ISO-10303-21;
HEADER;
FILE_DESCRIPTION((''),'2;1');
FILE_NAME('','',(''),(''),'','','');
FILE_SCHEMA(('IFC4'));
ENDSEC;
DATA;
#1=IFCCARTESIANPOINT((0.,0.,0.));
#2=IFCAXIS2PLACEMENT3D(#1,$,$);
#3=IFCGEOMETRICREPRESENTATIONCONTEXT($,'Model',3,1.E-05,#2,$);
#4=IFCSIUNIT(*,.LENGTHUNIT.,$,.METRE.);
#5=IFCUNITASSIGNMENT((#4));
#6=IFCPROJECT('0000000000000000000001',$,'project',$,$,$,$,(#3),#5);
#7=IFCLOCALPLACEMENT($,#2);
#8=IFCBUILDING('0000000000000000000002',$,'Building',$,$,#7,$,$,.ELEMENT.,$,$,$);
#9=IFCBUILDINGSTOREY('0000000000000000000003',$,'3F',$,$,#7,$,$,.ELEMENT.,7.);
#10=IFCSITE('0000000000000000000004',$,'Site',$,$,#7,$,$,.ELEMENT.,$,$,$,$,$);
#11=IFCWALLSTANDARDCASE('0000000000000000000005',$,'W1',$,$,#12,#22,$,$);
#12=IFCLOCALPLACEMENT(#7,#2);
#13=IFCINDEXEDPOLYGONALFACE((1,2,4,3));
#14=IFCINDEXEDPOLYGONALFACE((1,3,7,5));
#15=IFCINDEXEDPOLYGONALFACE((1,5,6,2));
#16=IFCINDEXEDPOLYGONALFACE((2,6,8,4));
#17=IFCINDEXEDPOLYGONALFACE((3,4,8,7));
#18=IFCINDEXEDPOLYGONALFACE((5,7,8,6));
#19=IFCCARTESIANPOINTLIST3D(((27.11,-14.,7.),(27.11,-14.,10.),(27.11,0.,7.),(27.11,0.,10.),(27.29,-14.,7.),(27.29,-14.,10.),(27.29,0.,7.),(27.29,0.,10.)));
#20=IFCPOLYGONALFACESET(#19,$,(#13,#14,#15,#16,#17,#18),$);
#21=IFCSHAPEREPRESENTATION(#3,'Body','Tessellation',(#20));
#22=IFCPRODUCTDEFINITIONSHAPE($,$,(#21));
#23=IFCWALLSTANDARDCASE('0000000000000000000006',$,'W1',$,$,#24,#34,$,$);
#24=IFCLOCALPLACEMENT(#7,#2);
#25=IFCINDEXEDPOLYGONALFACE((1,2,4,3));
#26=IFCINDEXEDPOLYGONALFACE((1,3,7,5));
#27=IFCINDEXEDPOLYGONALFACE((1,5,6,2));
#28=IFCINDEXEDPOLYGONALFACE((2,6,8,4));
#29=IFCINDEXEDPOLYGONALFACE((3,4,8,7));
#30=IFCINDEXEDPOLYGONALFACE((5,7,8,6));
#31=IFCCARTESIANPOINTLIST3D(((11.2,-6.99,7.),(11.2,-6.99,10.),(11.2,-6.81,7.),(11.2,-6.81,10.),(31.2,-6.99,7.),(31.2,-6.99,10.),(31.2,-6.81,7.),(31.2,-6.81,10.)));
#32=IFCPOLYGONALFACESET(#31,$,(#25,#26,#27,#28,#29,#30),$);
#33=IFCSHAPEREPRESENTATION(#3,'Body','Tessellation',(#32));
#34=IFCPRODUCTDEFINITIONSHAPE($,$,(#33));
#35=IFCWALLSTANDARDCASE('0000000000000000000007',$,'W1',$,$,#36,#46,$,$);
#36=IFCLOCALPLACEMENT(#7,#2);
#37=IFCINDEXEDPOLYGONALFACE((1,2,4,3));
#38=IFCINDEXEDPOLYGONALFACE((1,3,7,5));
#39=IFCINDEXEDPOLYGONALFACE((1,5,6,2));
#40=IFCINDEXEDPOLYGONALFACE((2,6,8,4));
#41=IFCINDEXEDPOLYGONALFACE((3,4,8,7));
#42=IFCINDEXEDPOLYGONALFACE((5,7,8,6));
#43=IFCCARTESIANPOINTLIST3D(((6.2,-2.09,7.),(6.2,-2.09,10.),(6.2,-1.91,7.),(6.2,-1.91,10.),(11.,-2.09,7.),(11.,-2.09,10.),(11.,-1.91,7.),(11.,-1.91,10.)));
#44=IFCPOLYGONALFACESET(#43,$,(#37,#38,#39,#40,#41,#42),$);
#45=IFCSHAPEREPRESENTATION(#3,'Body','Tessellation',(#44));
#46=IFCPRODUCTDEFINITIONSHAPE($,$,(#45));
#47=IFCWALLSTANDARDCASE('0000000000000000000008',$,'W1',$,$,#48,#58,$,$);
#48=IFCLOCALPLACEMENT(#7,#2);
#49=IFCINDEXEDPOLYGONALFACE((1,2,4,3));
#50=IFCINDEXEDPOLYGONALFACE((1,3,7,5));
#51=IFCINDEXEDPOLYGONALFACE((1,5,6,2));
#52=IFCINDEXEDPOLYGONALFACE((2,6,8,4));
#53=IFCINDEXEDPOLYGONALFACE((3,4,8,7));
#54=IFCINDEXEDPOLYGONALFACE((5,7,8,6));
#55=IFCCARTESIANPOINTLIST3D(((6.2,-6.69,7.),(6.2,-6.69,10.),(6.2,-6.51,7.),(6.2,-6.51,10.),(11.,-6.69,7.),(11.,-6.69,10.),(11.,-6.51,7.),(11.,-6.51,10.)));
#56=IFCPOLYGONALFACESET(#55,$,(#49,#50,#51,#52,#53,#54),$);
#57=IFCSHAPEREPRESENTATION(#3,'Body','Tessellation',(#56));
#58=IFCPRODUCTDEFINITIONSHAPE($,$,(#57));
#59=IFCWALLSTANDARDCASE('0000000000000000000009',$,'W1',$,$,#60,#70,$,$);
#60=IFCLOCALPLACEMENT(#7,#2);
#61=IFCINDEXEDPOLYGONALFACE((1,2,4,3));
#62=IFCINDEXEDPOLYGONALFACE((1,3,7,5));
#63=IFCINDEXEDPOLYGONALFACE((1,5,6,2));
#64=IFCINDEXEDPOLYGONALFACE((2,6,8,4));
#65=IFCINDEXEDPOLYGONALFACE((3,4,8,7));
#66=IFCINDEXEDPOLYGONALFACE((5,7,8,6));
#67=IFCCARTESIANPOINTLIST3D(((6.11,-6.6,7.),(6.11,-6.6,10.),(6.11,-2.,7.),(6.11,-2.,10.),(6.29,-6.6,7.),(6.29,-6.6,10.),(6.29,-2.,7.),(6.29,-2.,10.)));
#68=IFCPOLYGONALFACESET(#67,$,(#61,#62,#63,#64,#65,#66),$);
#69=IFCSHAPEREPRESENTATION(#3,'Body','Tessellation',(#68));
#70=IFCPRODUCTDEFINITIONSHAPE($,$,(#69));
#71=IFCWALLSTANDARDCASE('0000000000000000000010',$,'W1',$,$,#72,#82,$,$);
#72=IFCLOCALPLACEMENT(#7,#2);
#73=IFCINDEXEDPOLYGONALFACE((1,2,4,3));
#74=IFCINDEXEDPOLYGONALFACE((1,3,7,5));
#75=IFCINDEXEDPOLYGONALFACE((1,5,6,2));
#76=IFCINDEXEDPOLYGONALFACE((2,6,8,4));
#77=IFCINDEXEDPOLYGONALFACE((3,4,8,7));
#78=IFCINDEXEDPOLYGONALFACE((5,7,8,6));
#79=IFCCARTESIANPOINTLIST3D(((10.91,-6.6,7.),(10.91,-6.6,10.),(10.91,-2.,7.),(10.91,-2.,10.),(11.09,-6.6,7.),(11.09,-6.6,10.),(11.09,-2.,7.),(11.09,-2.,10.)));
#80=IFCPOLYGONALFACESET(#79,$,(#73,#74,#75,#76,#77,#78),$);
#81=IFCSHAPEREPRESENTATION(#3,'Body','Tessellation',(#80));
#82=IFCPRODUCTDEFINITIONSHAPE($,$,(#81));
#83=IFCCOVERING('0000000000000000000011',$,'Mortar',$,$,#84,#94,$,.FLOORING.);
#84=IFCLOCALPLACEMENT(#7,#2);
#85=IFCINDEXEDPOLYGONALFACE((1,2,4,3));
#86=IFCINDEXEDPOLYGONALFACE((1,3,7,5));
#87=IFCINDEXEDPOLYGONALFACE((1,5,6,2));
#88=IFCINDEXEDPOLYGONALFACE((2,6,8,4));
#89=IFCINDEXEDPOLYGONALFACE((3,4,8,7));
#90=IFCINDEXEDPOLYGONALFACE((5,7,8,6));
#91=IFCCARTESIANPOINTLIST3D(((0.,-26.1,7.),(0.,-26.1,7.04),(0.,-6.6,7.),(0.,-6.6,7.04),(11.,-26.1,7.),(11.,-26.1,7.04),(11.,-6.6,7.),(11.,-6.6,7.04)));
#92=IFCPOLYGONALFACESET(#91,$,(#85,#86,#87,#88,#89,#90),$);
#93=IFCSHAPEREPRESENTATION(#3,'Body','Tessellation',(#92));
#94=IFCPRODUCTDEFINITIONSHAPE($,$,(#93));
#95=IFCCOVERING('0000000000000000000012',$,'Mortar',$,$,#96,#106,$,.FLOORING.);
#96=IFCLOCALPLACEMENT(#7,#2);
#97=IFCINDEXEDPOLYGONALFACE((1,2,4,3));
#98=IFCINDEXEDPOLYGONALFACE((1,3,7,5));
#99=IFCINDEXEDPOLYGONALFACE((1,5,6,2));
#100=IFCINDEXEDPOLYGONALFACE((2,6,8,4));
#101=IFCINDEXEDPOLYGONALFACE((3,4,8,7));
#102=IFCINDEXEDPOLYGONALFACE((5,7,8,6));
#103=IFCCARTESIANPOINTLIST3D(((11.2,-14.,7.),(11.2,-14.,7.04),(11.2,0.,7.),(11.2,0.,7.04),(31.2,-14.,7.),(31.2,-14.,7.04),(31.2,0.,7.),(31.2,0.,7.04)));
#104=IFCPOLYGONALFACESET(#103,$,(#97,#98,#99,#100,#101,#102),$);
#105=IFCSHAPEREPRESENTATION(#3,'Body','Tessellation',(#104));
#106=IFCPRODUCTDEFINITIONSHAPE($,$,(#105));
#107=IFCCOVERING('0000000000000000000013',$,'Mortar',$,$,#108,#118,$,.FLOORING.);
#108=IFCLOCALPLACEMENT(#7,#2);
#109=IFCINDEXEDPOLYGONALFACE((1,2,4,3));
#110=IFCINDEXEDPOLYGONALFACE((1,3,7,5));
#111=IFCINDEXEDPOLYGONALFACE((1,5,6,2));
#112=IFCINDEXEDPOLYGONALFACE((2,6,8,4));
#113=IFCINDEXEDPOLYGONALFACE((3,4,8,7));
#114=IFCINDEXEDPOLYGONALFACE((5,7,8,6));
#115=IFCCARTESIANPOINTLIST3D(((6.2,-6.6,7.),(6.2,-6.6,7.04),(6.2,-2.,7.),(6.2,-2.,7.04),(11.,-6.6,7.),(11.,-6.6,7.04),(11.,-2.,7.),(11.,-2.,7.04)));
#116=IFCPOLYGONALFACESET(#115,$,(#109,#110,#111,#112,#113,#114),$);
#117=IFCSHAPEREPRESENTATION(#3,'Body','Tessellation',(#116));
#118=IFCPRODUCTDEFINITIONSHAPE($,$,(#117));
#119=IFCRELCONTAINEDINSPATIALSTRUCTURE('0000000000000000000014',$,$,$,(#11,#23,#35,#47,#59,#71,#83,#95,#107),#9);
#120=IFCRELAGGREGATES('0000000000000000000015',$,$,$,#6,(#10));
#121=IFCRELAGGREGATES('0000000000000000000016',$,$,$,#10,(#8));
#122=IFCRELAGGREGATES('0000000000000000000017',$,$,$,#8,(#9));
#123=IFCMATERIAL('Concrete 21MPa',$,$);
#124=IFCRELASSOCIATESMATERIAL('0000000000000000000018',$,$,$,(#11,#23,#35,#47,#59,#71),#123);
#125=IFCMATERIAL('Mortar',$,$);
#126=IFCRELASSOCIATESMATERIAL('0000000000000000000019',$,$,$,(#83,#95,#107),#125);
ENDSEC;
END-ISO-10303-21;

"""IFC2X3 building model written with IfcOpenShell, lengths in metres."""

from ifc_helpers import new_model, si_unit, frame, origin, origin_2d, place, context, project, spatial, rectangle, extrude, material, element, save


model = new_model("IFC2X3")

# Units and contexts
model_context = context("Model", 3, precision=1e-05, world=origin())
ifc_project = project(units=[si_unit("LENGTHUNIT", "METRE")], contexts=[model_context])

# Site, building, storey
placement = place(None, origin())
site = spatial("IfcSite", under=ifc_project, at=placement, Name="Site", CompositionType="ELEMENT")
building = spatial("IfcBuilding", under=site, at=placement, Name="Building", CompositionType="ELEMENT")
storey = spatial("IfcBuildingStorey", under=building, at=placement, Name="3F", CompositionType="ELEMENT", Elevation=7.0)

# Shared definitions
ifc_material_1 = material(Name="Concrete 21MPa")

# Walls
for number, where, name in (
    (1, (27.2, -7.0, 7.0), "W1"),
):
    element("IfcWallStandardCase", number, at=place(None, frame(where)), inside=storey, material=ifc_material_1, Name=name, context=model_context, shape_type="SweptSolid", body=[
        extrude(rectangle(XDim=0.18, YDim=14.0, at=origin_2d()), origin(), (0.0, 0.0, 1.0), 3.0),
    ])
wall_1_placement = place(None, frame((21.2, -6.9, 7.0)))
element("IfcWallStandardCase", 2, at=wall_1_placement, inside=storey, material=ifc_material_1, Name="W1", context=model_context, shape_type="SweptSolid", body=[
    extrude(rectangle(XDim=20.0, YDim=0.18, at=origin_2d()), origin(), (0.0, 0.0, 1.0), 3.0),
])
for number, where, name in (
    (3, (8.6, -2.0, 7.0), "W1"),
    (4, (8.6, -6.6, 7.0), "W1"),
):
    element("IfcWallStandardCase", number, at=place(None, frame(where)), inside=storey, material=ifc_material_1, Name=name, context=model_context, shape_type="SweptSolid", body=[
        extrude(rectangle(XDim=4.8, YDim=0.18, at=origin_2d()), origin(), (0.0, 0.0, 1.0), 3.0),
    ])
for number, where, name in (
    (5, (6.2, -4.3, 7.0), "W1"),
    (6, (11.0, -4.3, 7.0), "W1"),
):
    element("IfcWallStandardCase", number, at=place(None, frame(where)), inside=storey, material=ifc_material_1, Name=name, context=model_context, shape_type="SweptSolid", body=[
        extrude(rectangle(XDim=0.18, YDim=4.6, at=origin_2d()), origin(), (0.0, 0.0, 1.0), 3.0),
    ])

# Coverings
ifc_material_2 = material(Name="Mortar")
covering_1_placement = place(None, frame((5.5, -16.35, 7.0)))
element("IfcCovering", 7, at=covering_1_placement, inside=storey, material=ifc_material_2, Name="Mortar", PredefinedType="FLOORING", context=model_context, shape_type="SweptSolid", body=[
    extrude(rectangle(XDim=11.0, YDim=19.5, at=origin_2d()), origin(), (0.0, 0.0, 1.0), 0.04),
])
covering_2_placement = place(None, frame((21.2, -7.0, 7.0)))
element("IfcCovering", 8, at=covering_2_placement, inside=storey, material=ifc_material_2, Name="Mortar", PredefinedType="FLOORING", context=model_context, shape_type="SweptSolid", body=[
    extrude(rectangle(XDim=20.0, YDim=14.0, at=origin_2d()), origin(), (0.0, 0.0, 1.0), 0.04),
])
covering_3_placement = place(None, frame((8.6, -4.3, 7.0)))
element("IfcCovering", 9, at=covering_3_placement, inside=storey, material=ifc_material_2, Name="Mortar", PredefinedType="FLOORING", context=model_context, shape_type="SweptSolid", body=[
    extrude(rectangle(XDim=4.8, YDim=4.6, at=origin_2d()), origin(), (0.0, 0.0, 1.0), 0.04),
])

save(model, "model.ifc")
